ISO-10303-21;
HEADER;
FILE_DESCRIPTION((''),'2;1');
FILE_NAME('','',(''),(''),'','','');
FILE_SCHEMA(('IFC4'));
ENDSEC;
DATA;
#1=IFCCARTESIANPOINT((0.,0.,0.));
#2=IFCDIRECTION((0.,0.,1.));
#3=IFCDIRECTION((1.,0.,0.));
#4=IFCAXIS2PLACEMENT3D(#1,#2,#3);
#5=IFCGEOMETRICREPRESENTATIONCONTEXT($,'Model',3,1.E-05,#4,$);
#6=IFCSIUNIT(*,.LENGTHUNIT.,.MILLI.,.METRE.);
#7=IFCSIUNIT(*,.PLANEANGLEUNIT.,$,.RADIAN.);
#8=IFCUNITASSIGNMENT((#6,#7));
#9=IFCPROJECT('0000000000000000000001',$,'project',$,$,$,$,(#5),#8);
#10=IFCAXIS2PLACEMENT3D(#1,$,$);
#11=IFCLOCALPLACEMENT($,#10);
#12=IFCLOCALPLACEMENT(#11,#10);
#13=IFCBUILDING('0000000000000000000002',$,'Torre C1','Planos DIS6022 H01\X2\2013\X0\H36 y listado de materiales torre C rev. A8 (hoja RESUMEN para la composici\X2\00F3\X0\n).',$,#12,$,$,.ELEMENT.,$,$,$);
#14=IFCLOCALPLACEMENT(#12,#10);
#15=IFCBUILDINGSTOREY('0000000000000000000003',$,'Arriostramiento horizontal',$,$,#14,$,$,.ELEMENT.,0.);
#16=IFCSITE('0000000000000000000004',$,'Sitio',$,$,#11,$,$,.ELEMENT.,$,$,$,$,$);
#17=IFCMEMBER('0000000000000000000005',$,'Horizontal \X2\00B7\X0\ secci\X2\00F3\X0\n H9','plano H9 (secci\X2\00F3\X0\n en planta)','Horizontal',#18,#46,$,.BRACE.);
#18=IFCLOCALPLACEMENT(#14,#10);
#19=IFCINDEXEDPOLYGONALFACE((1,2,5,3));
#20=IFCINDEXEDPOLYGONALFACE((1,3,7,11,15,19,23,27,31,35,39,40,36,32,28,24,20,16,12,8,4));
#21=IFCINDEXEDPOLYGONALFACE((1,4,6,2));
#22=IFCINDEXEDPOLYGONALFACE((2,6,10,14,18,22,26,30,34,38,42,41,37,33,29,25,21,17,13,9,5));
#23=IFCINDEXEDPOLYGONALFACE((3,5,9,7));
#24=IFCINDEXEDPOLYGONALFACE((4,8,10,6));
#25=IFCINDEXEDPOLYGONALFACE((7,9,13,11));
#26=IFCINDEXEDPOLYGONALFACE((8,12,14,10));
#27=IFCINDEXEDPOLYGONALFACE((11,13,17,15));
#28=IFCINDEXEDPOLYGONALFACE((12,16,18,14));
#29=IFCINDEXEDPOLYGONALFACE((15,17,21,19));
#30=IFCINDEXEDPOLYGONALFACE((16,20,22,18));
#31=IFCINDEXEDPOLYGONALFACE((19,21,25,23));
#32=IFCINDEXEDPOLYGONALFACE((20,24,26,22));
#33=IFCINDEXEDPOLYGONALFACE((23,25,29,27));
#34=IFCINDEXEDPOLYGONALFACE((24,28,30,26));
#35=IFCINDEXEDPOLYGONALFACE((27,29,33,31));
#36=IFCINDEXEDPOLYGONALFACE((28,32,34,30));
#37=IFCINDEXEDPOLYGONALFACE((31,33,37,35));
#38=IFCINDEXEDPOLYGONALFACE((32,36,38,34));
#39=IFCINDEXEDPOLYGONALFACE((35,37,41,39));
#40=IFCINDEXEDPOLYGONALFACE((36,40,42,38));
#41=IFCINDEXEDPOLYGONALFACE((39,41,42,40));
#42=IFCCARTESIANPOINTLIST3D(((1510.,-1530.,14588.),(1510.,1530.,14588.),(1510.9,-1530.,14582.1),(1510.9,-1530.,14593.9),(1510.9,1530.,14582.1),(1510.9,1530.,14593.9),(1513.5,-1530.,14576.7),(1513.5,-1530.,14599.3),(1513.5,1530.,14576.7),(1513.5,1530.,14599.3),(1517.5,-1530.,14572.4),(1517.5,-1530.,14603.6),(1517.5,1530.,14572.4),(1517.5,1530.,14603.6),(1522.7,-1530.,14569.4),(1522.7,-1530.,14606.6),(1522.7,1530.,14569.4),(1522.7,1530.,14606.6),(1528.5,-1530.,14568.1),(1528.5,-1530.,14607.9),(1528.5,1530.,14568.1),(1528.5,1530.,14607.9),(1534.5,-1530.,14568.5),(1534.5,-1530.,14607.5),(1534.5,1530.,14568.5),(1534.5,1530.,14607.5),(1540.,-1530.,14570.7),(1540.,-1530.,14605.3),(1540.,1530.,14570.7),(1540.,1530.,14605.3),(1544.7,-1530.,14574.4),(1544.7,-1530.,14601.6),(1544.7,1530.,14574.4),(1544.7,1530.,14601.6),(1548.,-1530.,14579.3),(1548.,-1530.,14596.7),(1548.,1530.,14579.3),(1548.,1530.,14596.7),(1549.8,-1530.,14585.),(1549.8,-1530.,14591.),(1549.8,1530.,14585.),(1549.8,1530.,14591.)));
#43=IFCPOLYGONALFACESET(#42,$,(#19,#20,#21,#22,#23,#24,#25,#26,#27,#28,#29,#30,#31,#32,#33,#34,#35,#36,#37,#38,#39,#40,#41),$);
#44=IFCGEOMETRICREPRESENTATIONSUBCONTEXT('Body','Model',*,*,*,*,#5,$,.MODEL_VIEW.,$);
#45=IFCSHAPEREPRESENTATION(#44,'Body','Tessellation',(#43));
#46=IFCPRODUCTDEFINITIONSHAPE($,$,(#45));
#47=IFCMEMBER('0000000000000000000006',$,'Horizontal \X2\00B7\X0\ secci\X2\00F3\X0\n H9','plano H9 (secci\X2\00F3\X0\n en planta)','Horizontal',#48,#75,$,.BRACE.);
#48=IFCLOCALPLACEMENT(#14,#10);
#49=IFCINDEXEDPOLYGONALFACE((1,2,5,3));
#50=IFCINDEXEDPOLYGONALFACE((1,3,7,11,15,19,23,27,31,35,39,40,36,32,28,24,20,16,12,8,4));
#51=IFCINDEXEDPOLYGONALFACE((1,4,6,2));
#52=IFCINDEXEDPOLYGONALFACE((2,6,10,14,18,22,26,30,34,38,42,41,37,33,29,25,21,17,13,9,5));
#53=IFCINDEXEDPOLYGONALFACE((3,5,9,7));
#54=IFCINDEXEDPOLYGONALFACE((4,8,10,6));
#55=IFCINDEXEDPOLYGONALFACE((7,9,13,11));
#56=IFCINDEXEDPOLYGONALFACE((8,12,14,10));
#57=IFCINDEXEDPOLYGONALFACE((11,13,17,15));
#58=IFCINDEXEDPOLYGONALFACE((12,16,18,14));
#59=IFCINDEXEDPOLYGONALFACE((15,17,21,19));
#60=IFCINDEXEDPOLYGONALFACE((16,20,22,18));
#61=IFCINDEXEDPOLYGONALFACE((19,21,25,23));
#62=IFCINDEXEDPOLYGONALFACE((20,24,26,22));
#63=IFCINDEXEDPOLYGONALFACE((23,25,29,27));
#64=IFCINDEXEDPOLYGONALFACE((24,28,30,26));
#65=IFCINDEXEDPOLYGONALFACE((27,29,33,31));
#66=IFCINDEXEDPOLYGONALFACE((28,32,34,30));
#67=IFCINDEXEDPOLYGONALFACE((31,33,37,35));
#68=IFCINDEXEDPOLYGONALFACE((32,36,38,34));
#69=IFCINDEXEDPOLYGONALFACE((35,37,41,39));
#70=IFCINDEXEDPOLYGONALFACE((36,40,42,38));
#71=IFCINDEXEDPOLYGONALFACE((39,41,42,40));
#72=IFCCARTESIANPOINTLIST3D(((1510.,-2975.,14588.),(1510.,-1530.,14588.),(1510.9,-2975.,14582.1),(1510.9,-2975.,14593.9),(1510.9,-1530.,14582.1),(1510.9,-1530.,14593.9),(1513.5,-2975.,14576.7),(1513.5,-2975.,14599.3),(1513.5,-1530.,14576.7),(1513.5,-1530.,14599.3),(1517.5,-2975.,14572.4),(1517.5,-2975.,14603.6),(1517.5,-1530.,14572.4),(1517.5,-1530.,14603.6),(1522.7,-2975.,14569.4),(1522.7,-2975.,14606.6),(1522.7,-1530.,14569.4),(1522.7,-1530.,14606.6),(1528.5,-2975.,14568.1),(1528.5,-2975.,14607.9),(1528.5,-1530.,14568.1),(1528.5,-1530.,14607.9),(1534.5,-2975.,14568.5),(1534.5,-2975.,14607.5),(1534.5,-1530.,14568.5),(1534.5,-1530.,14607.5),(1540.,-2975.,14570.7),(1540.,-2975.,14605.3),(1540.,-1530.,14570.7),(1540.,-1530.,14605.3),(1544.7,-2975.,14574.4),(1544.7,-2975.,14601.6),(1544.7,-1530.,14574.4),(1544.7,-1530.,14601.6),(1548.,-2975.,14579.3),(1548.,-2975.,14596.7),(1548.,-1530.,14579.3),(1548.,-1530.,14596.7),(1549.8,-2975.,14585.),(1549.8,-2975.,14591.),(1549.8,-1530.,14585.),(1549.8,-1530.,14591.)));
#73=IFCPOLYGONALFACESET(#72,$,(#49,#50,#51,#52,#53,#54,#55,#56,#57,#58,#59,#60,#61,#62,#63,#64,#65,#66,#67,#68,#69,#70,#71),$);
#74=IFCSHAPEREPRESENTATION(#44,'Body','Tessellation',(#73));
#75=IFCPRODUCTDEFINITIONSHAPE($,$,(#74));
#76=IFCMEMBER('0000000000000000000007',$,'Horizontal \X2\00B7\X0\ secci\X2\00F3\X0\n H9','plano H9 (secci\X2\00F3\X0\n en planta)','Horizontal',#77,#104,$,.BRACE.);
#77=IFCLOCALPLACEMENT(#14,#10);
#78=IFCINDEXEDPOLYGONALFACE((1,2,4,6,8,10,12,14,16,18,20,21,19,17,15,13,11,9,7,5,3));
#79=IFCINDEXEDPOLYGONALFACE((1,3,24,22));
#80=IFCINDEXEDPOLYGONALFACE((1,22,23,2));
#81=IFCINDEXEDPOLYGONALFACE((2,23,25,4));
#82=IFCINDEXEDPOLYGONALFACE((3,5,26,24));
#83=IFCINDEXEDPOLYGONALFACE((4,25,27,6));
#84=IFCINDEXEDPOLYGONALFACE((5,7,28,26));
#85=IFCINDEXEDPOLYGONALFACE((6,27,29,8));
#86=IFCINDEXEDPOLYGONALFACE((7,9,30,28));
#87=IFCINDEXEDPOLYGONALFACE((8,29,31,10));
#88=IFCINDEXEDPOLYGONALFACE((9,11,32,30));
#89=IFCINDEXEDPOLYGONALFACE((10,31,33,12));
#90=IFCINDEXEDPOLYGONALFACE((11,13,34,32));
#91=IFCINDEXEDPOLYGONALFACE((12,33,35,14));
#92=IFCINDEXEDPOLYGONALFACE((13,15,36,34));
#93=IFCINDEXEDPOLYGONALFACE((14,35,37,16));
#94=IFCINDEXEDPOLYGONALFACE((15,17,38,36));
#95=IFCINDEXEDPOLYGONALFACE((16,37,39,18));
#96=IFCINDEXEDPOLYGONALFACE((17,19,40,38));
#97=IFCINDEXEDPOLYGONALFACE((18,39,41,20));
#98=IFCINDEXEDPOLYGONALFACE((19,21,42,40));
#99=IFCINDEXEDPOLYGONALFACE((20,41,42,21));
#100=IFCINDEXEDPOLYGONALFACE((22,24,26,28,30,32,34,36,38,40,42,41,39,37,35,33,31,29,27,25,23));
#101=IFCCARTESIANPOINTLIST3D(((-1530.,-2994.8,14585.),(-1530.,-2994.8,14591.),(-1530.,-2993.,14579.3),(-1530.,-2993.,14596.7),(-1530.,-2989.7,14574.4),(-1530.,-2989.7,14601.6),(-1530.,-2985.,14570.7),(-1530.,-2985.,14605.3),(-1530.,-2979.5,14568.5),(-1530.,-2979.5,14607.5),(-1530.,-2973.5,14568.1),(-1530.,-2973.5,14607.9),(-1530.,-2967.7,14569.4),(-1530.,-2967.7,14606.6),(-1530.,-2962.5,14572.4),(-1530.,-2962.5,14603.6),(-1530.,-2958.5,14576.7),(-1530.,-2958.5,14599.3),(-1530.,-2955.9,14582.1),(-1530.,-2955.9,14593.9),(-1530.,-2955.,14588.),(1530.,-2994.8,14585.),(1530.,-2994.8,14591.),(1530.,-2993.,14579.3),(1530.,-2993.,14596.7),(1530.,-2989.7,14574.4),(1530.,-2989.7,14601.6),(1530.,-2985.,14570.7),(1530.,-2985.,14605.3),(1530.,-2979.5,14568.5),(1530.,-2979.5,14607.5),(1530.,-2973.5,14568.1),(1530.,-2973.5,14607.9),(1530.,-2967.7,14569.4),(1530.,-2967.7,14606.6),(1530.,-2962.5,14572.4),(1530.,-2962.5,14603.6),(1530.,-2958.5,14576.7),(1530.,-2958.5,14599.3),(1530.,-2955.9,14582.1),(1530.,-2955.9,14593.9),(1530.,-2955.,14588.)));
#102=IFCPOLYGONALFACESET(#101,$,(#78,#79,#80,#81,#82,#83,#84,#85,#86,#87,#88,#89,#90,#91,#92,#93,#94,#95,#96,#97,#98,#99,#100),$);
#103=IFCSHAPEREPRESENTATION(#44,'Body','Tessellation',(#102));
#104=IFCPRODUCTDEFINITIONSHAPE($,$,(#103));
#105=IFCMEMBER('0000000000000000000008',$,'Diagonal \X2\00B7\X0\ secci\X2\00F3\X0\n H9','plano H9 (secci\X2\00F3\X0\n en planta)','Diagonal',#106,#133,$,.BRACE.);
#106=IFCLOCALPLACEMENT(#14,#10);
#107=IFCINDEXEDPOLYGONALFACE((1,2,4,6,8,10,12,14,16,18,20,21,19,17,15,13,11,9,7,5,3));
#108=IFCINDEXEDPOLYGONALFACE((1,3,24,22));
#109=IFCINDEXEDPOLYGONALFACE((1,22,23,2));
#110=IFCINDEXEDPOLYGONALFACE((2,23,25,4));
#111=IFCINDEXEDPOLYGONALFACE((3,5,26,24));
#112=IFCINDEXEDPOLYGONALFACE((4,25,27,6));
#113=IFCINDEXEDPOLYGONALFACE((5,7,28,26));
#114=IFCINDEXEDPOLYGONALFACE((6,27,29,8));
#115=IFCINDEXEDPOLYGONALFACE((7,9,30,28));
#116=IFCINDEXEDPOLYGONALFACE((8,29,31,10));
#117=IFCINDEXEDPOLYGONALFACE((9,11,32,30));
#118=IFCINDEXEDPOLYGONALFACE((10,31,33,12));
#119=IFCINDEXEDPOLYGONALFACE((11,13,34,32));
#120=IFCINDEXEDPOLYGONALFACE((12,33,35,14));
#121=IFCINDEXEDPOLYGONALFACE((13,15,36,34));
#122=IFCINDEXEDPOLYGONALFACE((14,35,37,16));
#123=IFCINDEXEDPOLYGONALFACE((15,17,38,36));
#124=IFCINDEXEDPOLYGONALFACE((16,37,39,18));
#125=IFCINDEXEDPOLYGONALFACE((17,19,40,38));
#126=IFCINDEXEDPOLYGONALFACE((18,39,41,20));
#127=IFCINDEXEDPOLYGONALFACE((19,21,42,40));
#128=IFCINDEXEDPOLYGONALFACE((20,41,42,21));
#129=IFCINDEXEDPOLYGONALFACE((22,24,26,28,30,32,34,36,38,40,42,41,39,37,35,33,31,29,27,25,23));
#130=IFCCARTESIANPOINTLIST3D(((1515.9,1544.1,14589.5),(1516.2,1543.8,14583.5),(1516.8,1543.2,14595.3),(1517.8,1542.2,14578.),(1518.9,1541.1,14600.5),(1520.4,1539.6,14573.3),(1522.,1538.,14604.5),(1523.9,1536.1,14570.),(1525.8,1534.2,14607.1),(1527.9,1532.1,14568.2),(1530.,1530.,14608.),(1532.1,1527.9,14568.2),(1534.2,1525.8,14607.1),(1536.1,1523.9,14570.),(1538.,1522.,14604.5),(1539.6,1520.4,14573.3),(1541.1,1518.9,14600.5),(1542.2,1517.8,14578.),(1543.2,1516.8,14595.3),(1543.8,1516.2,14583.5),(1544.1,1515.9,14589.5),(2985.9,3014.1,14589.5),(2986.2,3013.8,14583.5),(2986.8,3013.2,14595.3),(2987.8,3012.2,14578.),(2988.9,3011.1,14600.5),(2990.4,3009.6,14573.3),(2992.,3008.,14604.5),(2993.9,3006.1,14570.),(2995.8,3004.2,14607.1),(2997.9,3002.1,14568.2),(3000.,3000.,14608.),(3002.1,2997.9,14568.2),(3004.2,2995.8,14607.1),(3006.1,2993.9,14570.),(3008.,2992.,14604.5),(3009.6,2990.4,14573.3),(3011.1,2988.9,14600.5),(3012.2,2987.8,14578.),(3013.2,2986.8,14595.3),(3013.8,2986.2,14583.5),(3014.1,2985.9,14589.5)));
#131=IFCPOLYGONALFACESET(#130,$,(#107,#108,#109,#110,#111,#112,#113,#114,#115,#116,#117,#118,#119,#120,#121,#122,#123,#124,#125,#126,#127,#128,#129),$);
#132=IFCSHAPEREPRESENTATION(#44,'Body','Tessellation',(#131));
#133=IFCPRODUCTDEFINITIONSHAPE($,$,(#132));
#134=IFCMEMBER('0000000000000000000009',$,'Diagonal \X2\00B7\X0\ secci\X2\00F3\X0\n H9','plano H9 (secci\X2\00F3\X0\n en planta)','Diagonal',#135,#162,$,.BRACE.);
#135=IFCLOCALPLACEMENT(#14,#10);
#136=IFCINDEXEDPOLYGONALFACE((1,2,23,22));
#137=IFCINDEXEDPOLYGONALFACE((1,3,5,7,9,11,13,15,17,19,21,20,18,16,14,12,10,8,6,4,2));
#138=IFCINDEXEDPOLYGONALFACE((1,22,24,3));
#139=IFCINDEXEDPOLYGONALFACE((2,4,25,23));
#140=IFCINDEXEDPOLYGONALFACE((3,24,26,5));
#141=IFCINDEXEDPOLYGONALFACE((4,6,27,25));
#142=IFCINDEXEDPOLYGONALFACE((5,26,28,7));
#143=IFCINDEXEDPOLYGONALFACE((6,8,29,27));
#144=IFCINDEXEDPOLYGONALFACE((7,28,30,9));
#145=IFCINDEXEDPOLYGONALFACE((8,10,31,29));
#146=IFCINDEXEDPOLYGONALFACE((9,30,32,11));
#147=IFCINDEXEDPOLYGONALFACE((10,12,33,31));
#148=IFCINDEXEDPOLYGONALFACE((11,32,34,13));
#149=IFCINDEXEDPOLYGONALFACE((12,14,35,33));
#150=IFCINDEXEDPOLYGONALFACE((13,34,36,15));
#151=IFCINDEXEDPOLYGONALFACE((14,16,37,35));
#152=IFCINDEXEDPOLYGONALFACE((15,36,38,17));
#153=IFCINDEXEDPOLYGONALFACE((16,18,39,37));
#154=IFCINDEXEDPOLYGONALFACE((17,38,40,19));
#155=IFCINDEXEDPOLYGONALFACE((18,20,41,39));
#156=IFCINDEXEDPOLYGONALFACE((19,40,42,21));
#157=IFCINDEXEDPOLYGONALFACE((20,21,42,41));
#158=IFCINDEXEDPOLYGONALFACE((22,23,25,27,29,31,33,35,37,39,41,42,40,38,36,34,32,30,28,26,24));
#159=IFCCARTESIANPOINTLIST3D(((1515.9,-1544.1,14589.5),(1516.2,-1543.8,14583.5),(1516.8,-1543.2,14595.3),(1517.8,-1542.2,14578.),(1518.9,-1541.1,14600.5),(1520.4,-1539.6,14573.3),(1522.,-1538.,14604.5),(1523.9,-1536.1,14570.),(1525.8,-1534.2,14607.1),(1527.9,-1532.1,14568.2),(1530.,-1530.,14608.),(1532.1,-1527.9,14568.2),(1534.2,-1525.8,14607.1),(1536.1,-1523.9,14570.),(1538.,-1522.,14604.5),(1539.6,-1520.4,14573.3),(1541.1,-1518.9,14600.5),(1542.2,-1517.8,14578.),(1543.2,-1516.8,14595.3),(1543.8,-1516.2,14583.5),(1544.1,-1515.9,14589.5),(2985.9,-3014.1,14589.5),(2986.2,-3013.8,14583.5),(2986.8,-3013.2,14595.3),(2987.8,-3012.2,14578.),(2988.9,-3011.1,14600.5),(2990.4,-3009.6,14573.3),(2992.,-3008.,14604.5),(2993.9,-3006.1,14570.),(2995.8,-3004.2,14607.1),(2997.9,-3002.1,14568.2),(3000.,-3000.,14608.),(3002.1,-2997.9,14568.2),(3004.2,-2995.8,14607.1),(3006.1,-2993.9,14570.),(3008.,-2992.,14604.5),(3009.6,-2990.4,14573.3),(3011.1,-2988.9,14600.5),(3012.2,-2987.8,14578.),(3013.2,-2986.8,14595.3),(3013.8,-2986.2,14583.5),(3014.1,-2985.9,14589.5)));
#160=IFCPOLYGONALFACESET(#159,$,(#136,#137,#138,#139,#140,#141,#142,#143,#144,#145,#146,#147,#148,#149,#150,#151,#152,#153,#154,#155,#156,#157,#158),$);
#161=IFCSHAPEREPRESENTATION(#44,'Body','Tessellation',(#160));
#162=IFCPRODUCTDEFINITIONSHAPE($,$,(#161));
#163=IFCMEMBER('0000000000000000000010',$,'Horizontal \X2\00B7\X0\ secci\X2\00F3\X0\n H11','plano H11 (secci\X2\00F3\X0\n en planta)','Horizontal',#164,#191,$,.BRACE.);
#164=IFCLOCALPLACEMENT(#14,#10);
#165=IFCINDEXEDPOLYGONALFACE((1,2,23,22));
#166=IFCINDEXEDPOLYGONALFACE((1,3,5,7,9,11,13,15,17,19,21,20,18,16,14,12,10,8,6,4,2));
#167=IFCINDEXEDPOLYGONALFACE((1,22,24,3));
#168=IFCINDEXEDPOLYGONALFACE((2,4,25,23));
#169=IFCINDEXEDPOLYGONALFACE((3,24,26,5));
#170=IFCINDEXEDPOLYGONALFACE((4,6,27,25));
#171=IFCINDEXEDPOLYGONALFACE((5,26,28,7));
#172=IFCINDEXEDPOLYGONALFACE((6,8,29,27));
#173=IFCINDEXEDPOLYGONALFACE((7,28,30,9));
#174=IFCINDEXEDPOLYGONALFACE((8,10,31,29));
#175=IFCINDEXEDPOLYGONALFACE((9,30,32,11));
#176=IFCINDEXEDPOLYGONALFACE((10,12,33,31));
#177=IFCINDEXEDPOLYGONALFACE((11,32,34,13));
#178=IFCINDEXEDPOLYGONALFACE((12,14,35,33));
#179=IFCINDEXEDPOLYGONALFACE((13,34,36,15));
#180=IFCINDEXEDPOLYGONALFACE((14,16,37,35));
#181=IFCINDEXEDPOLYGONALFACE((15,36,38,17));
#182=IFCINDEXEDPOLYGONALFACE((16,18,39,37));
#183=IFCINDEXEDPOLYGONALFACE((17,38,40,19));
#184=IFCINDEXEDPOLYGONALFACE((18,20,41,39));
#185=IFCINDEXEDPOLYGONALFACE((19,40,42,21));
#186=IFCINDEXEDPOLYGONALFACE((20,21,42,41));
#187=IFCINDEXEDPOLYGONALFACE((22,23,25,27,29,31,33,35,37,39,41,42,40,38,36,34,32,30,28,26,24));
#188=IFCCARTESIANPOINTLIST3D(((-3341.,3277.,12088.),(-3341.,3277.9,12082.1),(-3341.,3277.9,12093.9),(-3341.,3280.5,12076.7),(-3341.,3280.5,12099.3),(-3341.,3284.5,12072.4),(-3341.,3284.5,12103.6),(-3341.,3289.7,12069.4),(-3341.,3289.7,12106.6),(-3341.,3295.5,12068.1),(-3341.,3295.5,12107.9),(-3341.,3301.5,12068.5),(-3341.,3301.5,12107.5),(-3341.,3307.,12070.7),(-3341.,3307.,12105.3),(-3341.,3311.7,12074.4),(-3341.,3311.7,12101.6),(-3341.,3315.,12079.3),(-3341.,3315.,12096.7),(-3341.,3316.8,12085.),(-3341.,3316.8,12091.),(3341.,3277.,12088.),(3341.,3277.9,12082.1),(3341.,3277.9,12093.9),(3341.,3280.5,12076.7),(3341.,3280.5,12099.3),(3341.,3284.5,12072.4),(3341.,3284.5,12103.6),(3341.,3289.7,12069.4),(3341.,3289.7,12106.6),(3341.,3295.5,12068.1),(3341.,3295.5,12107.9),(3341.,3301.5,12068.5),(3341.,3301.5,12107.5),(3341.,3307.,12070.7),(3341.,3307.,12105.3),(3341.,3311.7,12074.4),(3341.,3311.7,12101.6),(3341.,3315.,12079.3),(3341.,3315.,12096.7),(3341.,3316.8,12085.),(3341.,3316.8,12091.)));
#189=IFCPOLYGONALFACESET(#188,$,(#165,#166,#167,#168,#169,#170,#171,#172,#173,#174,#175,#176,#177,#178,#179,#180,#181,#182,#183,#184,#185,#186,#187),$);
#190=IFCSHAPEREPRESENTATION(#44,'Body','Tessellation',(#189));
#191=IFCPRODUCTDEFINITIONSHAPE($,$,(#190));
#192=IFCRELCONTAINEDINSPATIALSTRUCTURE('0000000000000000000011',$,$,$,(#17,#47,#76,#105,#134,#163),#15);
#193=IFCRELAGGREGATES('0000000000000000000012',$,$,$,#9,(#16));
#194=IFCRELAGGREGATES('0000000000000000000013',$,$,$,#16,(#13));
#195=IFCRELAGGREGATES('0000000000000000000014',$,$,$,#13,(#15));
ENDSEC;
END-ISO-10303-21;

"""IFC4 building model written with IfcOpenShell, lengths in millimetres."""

from ifc_helpers import new_model, si_unit, frame, origin, origin_with_axes, place, context, subcontext, project, spatial, circle, extrude, element, save


model = new_model("IFC4")

# Units and contexts
model_context = context("Model", 3, precision=1e-05, world=origin_with_axes())
body_context = subcontext(model_context, "Body", "Model", "MODEL_VIEW")
ifc_project = project(units=[si_unit("LENGTHUNIT", "METRE", prefix="MILLI"), si_unit("PLANEANGLEUNIT", "RADIAN")], contexts=[model_context])

# Site, building, storey
site_placement = place(None, origin())
site = spatial("IfcSite", under=ifc_project, at=site_placement, Name="Sitio", CompositionType="ELEMENT")
building_placement = place(site_placement, origin())
building = spatial("IfcBuilding", under=site, at=building_placement, Name="Torre C1", Description="Planos DIS6022 H01–H36 y listado de materiales torre C rev. A8 (hoja RESUMEN para la composición).", CompositionType="ELEMENT")
storey_placement = place(building_placement, origin())
storey = spatial("IfcBuildingStorey", under=building, at=storey_placement, Name="Arriostramiento horizontal", CompositionType="ELEMENT", Elevation=0.0)

# Members
member_1_placement = place(storey_placement, frame((1530.0, 1530.0, 14588.0), z_axis=(0.0, -1.0, 0.0), x_axis=(-1.0, 0.0, 0.0)))
element("IfcMember", 1, at=member_1_placement, inside=storey, Name="Horizontal · sección H9", Description="plano H9 (sección en planta)", ObjectType="Horizontal", PredefinedType="BRACE", context=body_context, shape_type="SweptSolid", body=[
    extrude(circle(Radius=20.0), None, (0.0, 0.0, 1.0), 3060.0),
])
member_2_placement = place(storey_placement, frame((1530.0, -1530.0, 14588.0), z_axis=(0.0, -1.0, 0.0), x_axis=(-1.0, 0.0, 0.0)))
element("IfcMember", 2, at=member_2_placement, inside=storey, Name="Horizontal · sección H9", Description="plano H9 (sección en planta)", ObjectType="Horizontal", PredefinedType="BRACE", context=body_context, shape_type="SweptSolid", body=[
    extrude(circle(Radius=20.0), None, (0.0, 0.0, 1.0), 1445.0),
])
member_3_placement = place(storey_placement, frame((1530.0, -2975.0, 14588.0), z_axis=(-1.0, 0.0, 0.0), x_axis=(0.0, 1.0, 0.0)))
element("IfcMember", 3, at=member_3_placement, inside=storey, Name="Horizontal · sección H9", Description="plano H9 (sección en planta)", ObjectType="Horizontal", PredefinedType="BRACE", context=body_context, shape_type="SweptSolid", body=[
    extrude(circle(Radius=20.0), None, (0.0, 0.0, 1.0), 3060.0),
])
for number, where, z_axis, x_axis, name in (
    (4, (3000.0, 3000.0, 14588.0), (-0.707107, -0.707107, 0.0), (0.0, 0.0, 1.0), "Diagonal · sección H9"),
    (5, (3000.0, -3000.0, 14588.0), (-0.707107, 0.707107, 0.0), (0.0, 0.0, 1.0), "Diagonal · sección H9"),
):
    element("IfcMember", number, at=place(storey_placement, frame(where, z_axis=z_axis, x_axis=x_axis)), inside=storey, Name=name, Description="plano H9 (sección en planta)", ObjectType="Diagonal", PredefinedType="BRACE", context=body_context, shape_type="SweptSolid", body=[
        extrude(circle(Radius=20.0), None, (0.0, 0.0, 1.0), 2078.9),
    ])
for number, where, z_axis, x_axis, name in (
    (6, (3341.0, 3297.0, 12088.0), (-1.0, 0.0, 0.0), (0.0, -1.0, 0.0), "Horizontal · sección H11"),
):
    element("IfcMember", number, at=place(storey_placement, frame(where, z_axis=z_axis, x_axis=x_axis)), inside=storey, Name=name, Description="plano H11 (sección en planta)", ObjectType="Horizontal", PredefinedType="BRACE", context=body_context, shape_type="SweptSolid", body=[
        extrude(circle(Radius=20.0), None, (0.0, 0.0, 1.0), 6682.0),
    ])

save(model, "model.ifc")
